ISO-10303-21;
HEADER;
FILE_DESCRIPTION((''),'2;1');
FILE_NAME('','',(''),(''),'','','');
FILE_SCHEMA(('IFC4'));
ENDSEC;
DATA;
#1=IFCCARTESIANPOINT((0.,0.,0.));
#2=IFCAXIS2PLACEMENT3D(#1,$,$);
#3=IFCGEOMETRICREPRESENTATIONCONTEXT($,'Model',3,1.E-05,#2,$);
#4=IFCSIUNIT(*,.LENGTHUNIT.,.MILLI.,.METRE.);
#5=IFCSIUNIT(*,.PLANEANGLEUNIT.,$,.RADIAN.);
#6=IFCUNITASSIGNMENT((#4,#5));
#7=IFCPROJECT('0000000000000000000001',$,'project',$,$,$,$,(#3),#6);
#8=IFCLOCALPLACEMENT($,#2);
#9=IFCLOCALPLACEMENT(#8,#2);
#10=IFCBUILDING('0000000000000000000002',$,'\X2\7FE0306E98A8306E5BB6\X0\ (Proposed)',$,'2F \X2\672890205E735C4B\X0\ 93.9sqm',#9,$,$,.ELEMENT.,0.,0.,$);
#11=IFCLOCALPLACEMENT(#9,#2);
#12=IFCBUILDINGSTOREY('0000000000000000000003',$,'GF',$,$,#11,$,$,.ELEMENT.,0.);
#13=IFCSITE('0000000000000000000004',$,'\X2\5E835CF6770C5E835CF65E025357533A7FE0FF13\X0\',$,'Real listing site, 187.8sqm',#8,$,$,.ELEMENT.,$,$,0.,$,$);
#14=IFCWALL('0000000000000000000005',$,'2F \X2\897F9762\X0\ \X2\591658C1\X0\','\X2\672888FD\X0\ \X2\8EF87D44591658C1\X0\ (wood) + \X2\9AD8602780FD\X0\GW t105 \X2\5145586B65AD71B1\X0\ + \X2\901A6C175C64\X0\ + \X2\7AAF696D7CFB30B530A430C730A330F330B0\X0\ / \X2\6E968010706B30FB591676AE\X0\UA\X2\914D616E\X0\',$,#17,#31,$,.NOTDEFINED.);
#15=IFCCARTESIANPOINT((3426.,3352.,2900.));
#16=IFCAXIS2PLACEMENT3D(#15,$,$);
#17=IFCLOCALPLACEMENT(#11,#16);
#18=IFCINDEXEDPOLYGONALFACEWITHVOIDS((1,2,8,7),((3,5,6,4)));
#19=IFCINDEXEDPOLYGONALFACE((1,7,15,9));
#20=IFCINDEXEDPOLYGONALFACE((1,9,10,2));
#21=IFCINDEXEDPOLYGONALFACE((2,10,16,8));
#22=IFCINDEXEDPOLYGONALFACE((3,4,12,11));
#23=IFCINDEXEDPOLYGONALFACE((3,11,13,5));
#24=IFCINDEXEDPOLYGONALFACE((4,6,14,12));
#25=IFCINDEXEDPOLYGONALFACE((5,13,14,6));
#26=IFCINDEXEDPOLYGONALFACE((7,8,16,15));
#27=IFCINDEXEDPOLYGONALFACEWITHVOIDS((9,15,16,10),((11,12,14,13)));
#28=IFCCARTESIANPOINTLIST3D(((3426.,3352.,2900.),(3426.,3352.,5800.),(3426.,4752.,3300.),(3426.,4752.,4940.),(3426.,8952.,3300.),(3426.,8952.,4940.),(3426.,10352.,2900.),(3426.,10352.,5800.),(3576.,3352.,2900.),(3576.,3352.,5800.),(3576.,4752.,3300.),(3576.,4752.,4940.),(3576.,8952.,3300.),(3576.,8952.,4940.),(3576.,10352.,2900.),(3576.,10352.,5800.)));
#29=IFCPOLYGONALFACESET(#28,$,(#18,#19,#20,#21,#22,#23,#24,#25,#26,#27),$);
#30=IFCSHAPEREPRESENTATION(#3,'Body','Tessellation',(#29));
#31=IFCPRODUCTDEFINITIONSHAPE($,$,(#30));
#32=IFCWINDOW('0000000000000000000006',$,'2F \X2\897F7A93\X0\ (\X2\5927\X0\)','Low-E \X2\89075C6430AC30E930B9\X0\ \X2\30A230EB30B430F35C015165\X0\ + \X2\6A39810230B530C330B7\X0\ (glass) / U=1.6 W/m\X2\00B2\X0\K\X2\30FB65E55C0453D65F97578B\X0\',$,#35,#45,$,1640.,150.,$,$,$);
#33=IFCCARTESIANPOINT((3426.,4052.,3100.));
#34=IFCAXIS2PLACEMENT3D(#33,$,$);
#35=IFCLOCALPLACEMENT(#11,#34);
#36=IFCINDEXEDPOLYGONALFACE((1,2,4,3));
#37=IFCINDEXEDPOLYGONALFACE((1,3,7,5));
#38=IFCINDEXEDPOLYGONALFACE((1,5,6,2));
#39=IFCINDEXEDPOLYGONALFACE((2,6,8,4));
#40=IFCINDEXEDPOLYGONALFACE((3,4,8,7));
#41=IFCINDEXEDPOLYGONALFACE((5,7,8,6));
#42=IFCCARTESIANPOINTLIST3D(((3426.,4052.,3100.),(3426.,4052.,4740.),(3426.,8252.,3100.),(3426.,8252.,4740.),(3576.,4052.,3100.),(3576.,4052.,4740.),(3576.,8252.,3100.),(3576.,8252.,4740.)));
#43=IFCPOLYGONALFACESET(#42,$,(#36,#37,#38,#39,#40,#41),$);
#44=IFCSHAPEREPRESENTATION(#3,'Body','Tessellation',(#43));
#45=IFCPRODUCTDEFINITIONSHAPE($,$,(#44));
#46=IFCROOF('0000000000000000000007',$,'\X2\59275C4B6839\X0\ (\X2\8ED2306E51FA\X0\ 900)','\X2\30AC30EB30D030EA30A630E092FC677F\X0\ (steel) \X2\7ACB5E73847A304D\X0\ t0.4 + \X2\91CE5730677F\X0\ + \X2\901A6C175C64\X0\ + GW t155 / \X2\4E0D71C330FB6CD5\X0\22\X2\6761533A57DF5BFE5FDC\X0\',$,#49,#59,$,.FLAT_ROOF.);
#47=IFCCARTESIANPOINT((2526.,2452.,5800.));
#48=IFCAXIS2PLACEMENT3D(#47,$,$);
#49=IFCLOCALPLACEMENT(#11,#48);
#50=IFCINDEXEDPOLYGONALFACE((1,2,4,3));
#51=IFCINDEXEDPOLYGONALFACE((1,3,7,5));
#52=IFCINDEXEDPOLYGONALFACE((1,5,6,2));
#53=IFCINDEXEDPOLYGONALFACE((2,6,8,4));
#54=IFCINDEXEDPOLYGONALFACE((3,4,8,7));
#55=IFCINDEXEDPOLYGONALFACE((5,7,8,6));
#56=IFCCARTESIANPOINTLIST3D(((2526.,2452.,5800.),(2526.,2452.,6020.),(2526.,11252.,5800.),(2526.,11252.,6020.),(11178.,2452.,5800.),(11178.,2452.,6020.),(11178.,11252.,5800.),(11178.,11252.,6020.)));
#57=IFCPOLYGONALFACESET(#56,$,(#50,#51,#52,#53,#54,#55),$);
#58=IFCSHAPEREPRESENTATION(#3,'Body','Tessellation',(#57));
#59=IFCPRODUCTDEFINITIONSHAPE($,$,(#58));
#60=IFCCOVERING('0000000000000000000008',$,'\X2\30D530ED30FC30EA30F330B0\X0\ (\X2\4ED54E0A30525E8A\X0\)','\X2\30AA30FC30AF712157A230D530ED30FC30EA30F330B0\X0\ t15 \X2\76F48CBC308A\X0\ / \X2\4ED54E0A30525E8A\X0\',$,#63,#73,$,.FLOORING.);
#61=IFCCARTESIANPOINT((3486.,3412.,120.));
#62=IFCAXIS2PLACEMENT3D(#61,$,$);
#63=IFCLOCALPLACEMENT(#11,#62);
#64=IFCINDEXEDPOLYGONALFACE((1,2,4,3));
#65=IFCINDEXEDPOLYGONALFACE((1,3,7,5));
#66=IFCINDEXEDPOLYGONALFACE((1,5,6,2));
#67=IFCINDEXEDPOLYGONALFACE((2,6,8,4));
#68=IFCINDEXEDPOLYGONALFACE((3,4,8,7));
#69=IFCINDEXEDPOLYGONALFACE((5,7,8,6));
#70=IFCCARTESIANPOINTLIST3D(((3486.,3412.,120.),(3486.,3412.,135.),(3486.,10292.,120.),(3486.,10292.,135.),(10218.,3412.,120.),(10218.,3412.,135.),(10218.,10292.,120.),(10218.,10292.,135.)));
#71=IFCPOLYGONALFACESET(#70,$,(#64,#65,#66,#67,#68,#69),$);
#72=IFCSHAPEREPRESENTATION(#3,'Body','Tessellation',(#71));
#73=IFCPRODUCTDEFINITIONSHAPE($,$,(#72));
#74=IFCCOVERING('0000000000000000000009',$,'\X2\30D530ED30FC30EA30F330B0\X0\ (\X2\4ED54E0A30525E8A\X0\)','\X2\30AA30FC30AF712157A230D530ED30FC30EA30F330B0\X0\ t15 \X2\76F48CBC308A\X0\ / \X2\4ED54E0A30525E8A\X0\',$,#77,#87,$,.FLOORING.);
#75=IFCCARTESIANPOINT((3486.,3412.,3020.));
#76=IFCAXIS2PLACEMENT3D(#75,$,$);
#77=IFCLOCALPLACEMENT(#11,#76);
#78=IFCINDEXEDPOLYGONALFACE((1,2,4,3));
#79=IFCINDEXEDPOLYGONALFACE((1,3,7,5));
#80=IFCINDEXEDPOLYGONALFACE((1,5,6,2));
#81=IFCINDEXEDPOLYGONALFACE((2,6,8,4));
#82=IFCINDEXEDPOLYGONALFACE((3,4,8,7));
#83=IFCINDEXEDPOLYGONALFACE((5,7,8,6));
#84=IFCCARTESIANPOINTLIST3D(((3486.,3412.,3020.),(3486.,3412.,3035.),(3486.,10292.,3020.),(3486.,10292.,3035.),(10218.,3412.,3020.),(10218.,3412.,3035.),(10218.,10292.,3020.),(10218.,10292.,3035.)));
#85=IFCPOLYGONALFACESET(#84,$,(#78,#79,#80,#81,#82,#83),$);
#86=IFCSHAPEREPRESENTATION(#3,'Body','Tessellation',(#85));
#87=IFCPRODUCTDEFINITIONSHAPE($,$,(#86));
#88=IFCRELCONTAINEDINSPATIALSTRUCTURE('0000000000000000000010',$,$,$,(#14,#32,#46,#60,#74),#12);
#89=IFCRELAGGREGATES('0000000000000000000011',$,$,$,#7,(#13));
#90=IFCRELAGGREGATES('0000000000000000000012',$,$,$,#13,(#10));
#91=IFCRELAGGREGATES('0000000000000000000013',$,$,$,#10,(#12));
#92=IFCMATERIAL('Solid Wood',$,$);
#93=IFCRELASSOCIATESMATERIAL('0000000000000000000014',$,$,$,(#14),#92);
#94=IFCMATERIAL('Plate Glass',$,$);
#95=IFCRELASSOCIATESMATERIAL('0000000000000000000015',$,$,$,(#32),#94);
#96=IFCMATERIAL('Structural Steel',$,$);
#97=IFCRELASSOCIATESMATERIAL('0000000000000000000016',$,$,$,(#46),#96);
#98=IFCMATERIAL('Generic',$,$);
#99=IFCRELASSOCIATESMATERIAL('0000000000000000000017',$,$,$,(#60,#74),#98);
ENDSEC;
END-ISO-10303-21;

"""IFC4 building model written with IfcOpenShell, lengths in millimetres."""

from ifc_helpers import new_model, si_unit, frame, frame_2d, origin, place, context, project, spatial, rectangle, extrude, material, element, fill, save


model = new_model("IFC4")

# Units and contexts
model_context = context("Model", 3, precision=1e-05, world=origin())
ifc_project = project(units=[si_unit("LENGTHUNIT", "METRE", prefix="MILLI"), si_unit("PLANEANGLEUNIT", "RADIAN")], contexts=[model_context])

# Site, building, storey
site_placement = place(None, origin())
site = spatial("IfcSite", under=ifc_project, at=site_placement, Name="広島県広島市南区翠３", ObjectType="Real listing site, 187.8sqm", CompositionType="ELEMENT", RefElevation=0.0)
building_placement = place(site_placement, origin())
building = spatial("IfcBuilding", under=site, at=building_placement, Name="翠の風の家 (Proposed)", ObjectType="2F 木造平屋 93.9sqm", CompositionType="ELEMENT", ElevationOfRefHeight=0.0, ElevationOfTerrain=0.0)
storey_placement = place(building_placement, origin())
storey = spatial("IfcBuildingStorey", under=building, at=storey_placement, Name="GF", CompositionType="ELEMENT", Elevation=0.0)

# Shared definitions
ifc_material_1 = material(Name="Solid Wood")

# Shared definitions
ifc_material_2 = material(Name="Plate Glass")

# Wall, opening, window
wall_1_placement = place(storey_placement, frame((3426.0, 3352.0, 2900.0)))
wall_1 = element("IfcWall", 1, at=wall_1_placement, inside=storey, material=ifc_material_1, Name="2F 西面 外壁", Description="木製 軸組外壁 (wood) + 高性能GW t105 充填断熱 + 通気層 + 窯業系サイディング / 準耐火・外皮UA配慮", PredefinedType="NOTDEFINED", context=model_context, shape_type="SweptSolid", body=[
    extrude(rectangle(XDim=150.0, YDim=7000.0, at=frame_2d((75.0, 3500.0))), frame((3426.0, 3352.0, 2900.0)), (0.0, 0.0, 1.0), 2900.0),
])
opening_1_placement = place(storey_placement, frame((3426.0, 4052.0, 3100.0)))
opening_1 = element("IfcOpeningElement", 2, at=opening_1_placement, cuts=wall_1, PredefinedType="NOTDEFINED", context=model_context, shape_type="SweptSolid", body=[
    extrude(rectangle(XDim=150.0, YDim=4200.0, at=frame_2d((75.0, 2100.0))), frame((3426.0, 4052.0, 3100.0)), (0.0, 0.0, 1.0), 1640.0),
])
window_1_placement = place(storey_placement, frame((3426.0, 4052.0, 3100.0)))
window_1 = element("IfcWindow", 3, at=window_1_placement, inside=storey, material=ifc_material_2, Name="2F 西窓 (大)", Description="Low-E 複層ガラス アルゴン封入 + 樹脂サッシ (glass) / U=1.6 W/m²K・日射取得型", OverallHeight=1640.0, OverallWidth=150.0, context=model_context, shape_type="SweptSolid", body=[
    extrude(rectangle(XDim=150.0, YDim=4200.0, at=frame_2d((75.0, 2100.0))), frame((3426.0, 4052.0, 3100.0)), (0.0, 0.0, 1.0), 1640.0),
])
fill(opening_1, window_1)

# Roof
ifc_material_3 = material(Name="Structural Steel")
roof_placement = place(storey_placement, frame((2526.0, 2452.0, 5800.0)))
element("IfcRoof", 4, at=roof_placement, inside=storey, material=ifc_material_3, Name="大屋根 (軒の出 900)", Description="ガルバリウム鋼板 (steel) 立平葺き t0.4 + 野地板 + 通気層 + GW t155 / 不燃・法22条区域対応", PredefinedType="FLAT_ROOF", context=model_context, shape_type="SweptSolid", body=[
    extrude(rectangle(XDim=8652.0, YDim=8800.0, at=frame_2d((4326.0, 4400.0))), frame((2526.0, 2452.0, 5800.0)), (0.0, 0.0, 1.0), 220.0),
])

# Coverings
ifc_material_4 = material(Name="Generic")
covering_1_placement = place(storey_placement, frame((3486.0, 3412.0, 120.0)))
element("IfcCovering", 5, at=covering_1_placement, inside=storey, material=ifc_material_4, Name="フローリング (仕上げ床)", Description="オーク無垢フローリング t15 直貼り / 仕上げ床", PredefinedType="FLOORING", context=model_context, shape_type="SweptSolid", body=[
    extrude(rectangle(XDim=6732.0, YDim=6880.0, at=frame_2d((3366.0, 3440.0))), frame((3486.0, 3412.0, 120.0)), (0.0, 0.0, 1.0), 15.0),
])
covering_2_placement = place(storey_placement, frame((3486.0, 3412.0, 3020.0)))
element("IfcCovering", 6, at=covering_2_placement, inside=storey, material=ifc_material_4, Name="フローリング (仕上げ床)", Description="オーク無垢フローリング t15 直貼り / 仕上げ床", PredefinedType="FLOORING", context=model_context, shape_type="SweptSolid", body=[
    extrude(rectangle(XDim=6732.0, YDim=6880.0, at=frame_2d((3366.0, 3440.0))), frame((3486.0, 3412.0, 3020.0)), (0.0, 0.0, 1.0), 15.0),
])

save(model, "model.ifc")
